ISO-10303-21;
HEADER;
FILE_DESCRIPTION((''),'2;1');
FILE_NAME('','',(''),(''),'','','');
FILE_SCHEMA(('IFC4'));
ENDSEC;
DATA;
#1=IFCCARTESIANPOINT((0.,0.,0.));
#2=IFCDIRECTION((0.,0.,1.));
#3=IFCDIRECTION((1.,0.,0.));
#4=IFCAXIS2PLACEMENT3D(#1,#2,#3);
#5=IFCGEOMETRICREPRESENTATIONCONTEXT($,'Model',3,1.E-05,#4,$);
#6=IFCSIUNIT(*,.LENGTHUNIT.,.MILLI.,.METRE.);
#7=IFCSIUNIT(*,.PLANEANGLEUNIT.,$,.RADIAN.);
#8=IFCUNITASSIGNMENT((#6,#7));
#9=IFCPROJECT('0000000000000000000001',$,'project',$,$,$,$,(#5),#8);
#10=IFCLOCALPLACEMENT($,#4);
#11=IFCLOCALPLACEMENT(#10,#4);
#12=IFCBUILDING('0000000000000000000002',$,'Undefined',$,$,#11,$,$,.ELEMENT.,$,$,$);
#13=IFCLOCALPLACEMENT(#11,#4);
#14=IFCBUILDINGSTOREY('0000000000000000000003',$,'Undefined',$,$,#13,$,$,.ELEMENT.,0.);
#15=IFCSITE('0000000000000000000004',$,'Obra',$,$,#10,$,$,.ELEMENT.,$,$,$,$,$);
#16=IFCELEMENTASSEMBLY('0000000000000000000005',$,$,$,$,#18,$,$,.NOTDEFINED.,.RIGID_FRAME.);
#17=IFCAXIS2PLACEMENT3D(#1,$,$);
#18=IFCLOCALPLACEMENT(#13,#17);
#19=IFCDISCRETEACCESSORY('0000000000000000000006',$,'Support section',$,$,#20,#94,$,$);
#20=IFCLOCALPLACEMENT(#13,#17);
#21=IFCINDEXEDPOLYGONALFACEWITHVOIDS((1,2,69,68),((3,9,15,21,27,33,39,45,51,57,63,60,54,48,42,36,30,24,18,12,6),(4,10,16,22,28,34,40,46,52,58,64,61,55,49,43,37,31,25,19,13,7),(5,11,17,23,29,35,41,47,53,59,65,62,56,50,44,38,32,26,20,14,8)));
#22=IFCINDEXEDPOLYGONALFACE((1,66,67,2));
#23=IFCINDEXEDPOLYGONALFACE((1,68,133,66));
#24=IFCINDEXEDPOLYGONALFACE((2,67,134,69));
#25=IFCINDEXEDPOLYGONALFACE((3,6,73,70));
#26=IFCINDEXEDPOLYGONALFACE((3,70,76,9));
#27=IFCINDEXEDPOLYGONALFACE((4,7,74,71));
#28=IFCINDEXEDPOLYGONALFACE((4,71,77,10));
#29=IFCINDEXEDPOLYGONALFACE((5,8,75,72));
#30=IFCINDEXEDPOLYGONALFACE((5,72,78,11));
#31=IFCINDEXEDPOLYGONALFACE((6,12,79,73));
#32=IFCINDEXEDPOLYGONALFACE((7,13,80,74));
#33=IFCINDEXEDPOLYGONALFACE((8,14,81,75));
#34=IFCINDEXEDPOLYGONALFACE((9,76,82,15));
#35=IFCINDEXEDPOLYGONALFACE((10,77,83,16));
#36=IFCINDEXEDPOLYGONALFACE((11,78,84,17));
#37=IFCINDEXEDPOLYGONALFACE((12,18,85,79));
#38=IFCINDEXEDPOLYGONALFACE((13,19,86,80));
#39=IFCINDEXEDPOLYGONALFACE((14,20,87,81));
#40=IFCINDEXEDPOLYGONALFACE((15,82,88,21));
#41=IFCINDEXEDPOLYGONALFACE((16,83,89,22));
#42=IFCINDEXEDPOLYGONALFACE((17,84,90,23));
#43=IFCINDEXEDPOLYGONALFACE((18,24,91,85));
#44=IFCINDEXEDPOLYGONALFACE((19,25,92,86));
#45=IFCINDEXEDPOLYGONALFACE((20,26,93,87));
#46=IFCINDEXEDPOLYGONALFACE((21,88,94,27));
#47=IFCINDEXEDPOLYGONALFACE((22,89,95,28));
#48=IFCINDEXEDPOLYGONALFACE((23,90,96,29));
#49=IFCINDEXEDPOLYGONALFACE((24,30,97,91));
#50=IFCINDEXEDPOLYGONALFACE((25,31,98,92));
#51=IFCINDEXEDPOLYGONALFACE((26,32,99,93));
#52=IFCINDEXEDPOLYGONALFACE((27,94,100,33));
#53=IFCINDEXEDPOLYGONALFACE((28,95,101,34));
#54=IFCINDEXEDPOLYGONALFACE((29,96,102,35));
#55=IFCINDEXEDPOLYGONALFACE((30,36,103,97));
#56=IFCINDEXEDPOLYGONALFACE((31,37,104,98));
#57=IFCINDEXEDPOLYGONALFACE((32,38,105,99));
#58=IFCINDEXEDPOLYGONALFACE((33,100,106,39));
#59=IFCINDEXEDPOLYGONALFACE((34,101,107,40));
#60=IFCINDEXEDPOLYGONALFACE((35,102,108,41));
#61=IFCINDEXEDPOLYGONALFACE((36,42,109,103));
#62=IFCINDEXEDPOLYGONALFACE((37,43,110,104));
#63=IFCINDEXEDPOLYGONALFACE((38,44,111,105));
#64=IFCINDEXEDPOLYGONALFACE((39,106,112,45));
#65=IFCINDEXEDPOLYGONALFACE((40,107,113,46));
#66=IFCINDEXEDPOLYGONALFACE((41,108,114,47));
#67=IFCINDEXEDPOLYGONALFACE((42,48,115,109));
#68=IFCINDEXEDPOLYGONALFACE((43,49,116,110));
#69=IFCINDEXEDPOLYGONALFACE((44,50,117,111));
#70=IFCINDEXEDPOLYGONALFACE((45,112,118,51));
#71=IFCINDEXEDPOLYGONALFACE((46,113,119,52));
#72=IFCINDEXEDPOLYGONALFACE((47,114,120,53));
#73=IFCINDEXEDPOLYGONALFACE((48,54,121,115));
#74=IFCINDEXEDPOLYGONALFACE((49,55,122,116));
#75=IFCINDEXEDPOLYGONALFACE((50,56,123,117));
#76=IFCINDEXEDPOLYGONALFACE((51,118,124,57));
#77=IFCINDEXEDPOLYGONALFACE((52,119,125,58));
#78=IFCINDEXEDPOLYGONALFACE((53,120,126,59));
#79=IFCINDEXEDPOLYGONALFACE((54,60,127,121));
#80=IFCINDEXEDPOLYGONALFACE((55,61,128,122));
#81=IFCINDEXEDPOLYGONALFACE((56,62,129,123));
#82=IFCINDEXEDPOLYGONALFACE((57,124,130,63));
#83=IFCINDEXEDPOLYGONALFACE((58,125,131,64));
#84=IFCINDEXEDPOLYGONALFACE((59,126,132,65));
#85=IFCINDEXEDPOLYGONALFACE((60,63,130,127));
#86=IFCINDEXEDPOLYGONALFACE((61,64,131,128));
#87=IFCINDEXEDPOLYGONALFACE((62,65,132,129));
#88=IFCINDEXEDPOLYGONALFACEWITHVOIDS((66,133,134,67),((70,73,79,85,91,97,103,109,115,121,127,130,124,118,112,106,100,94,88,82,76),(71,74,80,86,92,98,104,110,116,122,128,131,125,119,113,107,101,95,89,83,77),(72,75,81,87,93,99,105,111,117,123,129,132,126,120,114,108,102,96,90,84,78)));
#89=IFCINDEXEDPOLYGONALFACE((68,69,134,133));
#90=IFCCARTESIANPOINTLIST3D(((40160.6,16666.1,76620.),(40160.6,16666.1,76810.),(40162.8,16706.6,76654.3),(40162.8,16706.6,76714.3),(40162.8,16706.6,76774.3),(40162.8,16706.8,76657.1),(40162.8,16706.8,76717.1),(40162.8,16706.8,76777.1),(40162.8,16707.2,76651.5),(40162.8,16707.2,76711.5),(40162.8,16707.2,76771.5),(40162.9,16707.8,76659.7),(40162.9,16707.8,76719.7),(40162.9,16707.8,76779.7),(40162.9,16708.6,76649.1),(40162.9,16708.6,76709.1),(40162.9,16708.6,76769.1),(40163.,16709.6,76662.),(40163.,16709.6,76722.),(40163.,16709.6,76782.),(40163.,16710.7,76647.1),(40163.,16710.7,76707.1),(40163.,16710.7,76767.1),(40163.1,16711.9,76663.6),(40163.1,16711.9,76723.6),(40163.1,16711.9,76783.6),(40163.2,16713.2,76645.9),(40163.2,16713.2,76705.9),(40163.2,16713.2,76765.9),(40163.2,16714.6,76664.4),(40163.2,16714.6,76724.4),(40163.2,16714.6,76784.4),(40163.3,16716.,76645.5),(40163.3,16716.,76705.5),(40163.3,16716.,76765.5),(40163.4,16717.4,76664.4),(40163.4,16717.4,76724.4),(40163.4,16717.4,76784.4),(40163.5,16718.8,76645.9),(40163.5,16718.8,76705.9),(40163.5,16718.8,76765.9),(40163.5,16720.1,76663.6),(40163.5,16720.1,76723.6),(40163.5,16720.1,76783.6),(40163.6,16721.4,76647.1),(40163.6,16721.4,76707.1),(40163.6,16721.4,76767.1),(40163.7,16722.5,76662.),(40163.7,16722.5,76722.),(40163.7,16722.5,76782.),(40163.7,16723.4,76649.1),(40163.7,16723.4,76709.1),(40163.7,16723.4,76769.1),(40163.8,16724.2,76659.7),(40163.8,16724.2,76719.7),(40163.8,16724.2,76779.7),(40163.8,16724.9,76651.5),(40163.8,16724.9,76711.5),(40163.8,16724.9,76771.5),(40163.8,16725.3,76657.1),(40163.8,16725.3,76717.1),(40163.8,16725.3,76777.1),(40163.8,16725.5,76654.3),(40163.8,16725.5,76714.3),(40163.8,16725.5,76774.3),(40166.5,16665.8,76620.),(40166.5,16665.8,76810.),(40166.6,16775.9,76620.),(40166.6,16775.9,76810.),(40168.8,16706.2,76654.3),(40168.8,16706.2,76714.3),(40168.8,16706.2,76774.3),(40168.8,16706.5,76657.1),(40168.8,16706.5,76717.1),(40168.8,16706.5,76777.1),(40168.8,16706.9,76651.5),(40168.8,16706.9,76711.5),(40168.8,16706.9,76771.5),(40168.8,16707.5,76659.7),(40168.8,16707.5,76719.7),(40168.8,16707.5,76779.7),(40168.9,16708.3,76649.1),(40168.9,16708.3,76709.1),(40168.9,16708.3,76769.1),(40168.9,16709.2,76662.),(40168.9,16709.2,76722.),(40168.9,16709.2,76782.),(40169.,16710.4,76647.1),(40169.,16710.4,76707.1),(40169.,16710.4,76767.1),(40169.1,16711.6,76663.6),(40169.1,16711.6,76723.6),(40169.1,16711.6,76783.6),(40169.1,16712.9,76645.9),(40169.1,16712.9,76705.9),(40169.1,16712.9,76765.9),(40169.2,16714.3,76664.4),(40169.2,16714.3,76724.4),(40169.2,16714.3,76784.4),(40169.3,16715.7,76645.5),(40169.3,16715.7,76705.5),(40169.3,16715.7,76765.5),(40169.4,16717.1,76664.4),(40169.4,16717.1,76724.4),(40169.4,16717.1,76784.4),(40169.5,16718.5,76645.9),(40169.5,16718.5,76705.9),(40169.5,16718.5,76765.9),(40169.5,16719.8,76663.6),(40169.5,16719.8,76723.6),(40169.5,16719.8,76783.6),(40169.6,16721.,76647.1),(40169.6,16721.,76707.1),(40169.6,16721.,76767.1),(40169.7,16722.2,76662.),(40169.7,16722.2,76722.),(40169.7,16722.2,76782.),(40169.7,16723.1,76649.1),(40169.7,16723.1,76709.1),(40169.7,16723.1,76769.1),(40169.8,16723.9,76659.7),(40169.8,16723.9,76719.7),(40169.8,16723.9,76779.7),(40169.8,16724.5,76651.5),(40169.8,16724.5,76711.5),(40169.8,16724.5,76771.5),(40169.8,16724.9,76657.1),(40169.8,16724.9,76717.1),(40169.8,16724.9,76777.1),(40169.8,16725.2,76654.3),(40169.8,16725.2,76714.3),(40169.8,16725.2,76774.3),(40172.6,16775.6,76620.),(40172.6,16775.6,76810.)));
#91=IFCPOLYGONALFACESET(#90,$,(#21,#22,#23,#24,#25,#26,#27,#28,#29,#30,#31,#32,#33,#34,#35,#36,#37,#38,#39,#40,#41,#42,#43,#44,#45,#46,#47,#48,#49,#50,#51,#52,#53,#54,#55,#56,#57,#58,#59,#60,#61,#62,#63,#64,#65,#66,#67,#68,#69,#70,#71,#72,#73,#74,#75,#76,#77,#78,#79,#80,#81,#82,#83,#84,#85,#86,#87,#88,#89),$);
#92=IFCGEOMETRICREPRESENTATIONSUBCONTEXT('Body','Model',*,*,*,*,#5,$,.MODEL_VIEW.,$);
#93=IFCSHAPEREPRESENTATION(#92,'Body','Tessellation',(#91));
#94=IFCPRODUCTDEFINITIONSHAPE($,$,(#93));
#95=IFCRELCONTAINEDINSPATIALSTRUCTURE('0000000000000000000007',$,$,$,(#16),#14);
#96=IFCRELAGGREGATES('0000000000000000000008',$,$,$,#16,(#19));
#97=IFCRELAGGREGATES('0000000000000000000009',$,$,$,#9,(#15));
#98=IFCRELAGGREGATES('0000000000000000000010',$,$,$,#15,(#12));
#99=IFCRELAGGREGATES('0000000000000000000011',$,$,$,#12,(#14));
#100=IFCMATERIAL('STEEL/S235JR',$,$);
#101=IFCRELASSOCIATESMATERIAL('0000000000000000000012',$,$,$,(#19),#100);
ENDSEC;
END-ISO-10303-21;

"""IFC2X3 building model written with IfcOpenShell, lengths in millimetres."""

from ifc_helpers import new_model, si_unit, frame, origin_with_axes, origin_2d_with_axis, place, context, subcontext, project, spatial, rectangle, circle, extrude, source, transform, mapped, material, element, aggregate, save


model = new_model("IFC2X3")

# Units and contexts
model_context = context("Model", 3, precision=1e-05, world=origin_with_axes())
body_context = subcontext(model_context, "Body", "Model", "MODEL_VIEW")
ifc_project = project(units=[si_unit("LENGTHUNIT", "METRE", prefix="MILLI"), si_unit("PLANEANGLEUNIT", "RADIAN")], contexts=[model_context])

# Site, building, storey
site_placement = place(None, origin_with_axes())
site = spatial("IfcSite", under=ifc_project, at=site_placement, Name="Obra", CompositionType="ELEMENT")
building_placement = place(site_placement, origin_with_axes())
building = spatial("IfcBuilding", under=site, at=building_placement, Name="Undefined", CompositionType="ELEMENT")
storey_placement = place(building_placement, origin_with_axes())
storey = spatial("IfcBuildingStorey", under=building, at=storey_placement, Name="Undefined", CompositionType="ELEMENT", Elevation=0.0)

# Element assembly
ifc_material_1 = material(Name="STEEL/S235JR")
assembly_1_placement = place(storey_placement, origin_with_axes())
assembly_1 = element("IfcElementAssembly", 1, at=assembly_1_placement, inside=storey, AssemblyPlace="NOTDEFINED", PredefinedType="RIGID_FRAME")

# Discrete accessory, opening
shared_shape = source(origin_with_axes(), body_context, "Body", "SweptSolid", [
    extrude(circle(Radius=9.5, at=origin_2d_with_axis()), frame((0.0, -9.2, 0.0), z_axis=(0.0, 1.0, 0.0), x_axis=(1.0, 0.0, 0.0)), (0.0, 0.0, 1.0), 6.2),
])
discrete_accessory_1_placement = place(assembly_1_placement, frame((40166.6, 16720.9, 76620.0), z_axis=(0.0, 0.0, 1.0), x_axis=(0.055268, 0.998472, 0.0)))
discrete_accessory_1 = element("IfcDiscreteAccessory", 2, at=discrete_accessory_1_placement, material=ifc_material_1, Name="Support section", context=body_context, shape_type="SweptSolid", body=[
    extrude(rectangle(XDim=6.0, YDim=110.0, at=origin_2d_with_axis()), frame((0.0, 0.0, 190.0), z_axis=(0.0, 0.0, -1.0), x_axis=(0.0, 1.0, 0.0)), (0.0, 0.0, 1.0), 190.0),
])
opening_1_placement = place(assembly_1_placement, frame((40175.2, 16765.5, 76835.0), z_axis=(-0.055268, -0.998472, 0.0), x_axis=(0.0, 0.0, -1.0)))
element("IfcOpeningElement", 3, at=opening_1_placement, cuts=discrete_accessory_1, ObjectType="Opening", context=body_context, shape_type="MappedRepresentation", body=[
    mapped(shared_shape, transform((60.0, 0.0, 50.0))),
    mapped(shared_shape, transform((120.0, 0.0, 50.0))),
    mapped(shared_shape, transform((180.0, 0.0, 50.0))),
])
aggregate(assembly_1, [discrete_accessory_1])

save(model, "model.ifc")
